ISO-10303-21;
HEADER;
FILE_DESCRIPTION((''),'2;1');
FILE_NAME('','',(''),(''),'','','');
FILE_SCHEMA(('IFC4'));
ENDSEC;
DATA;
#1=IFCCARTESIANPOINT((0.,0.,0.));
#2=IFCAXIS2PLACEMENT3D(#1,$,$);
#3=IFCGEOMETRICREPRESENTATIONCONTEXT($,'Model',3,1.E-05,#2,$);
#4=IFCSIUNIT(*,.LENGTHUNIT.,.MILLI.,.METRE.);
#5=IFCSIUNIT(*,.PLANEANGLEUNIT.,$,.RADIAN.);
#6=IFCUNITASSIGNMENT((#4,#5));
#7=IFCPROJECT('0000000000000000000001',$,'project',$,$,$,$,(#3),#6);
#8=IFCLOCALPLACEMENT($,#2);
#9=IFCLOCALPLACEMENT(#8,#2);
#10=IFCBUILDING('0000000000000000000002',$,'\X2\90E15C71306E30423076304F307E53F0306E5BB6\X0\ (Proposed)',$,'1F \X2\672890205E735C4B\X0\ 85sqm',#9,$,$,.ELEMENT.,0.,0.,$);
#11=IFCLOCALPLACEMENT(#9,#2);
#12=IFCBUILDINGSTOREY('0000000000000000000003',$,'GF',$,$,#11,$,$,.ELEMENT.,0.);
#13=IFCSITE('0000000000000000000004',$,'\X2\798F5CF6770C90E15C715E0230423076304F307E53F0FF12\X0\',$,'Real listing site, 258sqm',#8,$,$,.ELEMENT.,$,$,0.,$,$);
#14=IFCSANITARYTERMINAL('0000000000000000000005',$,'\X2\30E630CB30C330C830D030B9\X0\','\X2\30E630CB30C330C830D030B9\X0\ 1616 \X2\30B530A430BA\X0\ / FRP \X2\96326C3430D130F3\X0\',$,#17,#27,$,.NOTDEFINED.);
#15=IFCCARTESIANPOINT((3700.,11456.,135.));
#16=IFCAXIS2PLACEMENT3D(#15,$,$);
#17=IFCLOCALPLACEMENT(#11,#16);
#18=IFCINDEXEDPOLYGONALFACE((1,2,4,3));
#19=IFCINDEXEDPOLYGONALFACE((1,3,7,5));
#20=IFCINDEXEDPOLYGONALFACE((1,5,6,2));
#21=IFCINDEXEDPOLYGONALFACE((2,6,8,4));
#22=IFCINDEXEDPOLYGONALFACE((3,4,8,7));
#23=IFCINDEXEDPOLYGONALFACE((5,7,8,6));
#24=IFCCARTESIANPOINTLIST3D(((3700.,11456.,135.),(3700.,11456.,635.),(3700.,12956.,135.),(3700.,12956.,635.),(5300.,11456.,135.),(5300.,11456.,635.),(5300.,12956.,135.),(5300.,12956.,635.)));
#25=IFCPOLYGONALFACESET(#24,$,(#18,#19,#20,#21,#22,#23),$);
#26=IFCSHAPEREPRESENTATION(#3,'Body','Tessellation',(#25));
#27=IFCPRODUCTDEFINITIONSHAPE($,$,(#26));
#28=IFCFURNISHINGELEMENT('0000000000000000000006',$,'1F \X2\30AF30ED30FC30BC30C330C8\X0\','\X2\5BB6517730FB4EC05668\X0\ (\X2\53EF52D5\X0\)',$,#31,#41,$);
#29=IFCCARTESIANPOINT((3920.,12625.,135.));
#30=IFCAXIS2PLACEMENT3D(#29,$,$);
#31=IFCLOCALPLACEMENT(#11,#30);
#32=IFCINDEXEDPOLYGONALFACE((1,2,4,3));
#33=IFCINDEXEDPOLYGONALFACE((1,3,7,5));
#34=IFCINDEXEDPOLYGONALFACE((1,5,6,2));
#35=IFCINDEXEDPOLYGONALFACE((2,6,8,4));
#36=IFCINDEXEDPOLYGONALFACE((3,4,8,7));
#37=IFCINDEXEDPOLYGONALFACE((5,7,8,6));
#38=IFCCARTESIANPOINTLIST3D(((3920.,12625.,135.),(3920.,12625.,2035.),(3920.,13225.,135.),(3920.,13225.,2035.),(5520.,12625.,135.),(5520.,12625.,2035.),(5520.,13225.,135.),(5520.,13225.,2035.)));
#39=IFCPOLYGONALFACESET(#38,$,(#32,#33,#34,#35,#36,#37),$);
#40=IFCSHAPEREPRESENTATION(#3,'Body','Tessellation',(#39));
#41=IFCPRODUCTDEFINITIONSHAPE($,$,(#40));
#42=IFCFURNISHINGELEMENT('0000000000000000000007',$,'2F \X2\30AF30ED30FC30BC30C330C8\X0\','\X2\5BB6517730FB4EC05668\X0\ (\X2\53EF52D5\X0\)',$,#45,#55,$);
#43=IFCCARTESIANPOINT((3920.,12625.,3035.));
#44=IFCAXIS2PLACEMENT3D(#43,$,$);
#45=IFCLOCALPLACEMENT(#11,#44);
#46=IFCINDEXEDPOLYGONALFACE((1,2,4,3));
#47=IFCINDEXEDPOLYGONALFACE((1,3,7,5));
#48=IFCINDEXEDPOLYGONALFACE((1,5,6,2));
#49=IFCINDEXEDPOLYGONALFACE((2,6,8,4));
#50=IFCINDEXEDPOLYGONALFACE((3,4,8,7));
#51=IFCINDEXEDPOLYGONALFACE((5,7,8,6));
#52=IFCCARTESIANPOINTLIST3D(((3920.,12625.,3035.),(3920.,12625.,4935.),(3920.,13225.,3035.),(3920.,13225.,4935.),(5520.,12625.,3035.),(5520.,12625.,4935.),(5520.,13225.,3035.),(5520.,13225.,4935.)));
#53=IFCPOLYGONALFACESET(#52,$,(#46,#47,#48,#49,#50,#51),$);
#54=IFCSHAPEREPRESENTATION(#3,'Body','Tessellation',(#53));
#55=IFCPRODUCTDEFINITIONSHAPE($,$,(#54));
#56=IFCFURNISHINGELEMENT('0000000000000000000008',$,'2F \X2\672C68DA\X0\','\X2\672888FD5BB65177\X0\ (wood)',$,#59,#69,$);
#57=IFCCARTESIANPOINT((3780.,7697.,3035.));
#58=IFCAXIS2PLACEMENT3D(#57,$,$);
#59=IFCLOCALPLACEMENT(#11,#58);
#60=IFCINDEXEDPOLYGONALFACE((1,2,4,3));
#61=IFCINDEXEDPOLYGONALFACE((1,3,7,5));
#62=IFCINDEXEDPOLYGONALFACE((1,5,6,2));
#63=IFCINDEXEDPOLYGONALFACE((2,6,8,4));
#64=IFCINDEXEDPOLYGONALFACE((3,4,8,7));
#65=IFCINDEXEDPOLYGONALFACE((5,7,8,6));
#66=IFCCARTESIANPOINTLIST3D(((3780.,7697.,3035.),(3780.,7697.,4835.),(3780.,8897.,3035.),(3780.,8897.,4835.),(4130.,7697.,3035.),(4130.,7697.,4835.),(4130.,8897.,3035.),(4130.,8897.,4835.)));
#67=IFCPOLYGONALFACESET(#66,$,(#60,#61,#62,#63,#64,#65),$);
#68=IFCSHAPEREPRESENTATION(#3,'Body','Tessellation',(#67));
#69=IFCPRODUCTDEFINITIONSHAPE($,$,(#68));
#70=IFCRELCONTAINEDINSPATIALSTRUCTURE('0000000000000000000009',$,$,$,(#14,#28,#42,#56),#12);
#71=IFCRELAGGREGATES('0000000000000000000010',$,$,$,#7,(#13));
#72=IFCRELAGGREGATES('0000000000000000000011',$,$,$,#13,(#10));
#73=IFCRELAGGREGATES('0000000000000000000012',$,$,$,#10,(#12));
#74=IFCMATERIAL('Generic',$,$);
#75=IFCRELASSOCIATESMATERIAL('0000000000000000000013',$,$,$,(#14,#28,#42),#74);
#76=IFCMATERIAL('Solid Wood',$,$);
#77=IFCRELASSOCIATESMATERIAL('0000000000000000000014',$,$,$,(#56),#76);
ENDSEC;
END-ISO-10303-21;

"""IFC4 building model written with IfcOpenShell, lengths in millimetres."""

from ifc_helpers import new_model, si_unit, frame, frame_2d, origin, place, context, project, spatial, rectangle, extrude, material, element, save


model = new_model("IFC4")

# Units and contexts
model_context = context("Model", 3, precision=1e-05, world=origin())
ifc_project = project(units=[si_unit("LENGTHUNIT", "METRE", prefix="MILLI"), si_unit("PLANEANGLEUNIT", "RADIAN")], contexts=[model_context])

# Site, building, storey
site_placement = place(None, origin())
site = spatial("IfcSite", under=ifc_project, at=site_placement, Name="福島県郡山市あぶくま台２", ObjectType="Real listing site, 258sqm", CompositionType="ELEMENT", RefElevation=0.0)
building_placement = place(site_placement, origin())
building = spatial("IfcBuilding", under=site, at=building_placement, Name="郡山のあぶくま台の家 (Proposed)", ObjectType="1F 木造平屋 85sqm", CompositionType="ELEMENT", ElevationOfRefHeight=0.0, ElevationOfTerrain=0.0)
storey_placement = place(building_placement, origin())
storey = spatial("IfcBuildingStorey", under=building, at=storey_placement, Name="GF", CompositionType="ELEMENT", Elevation=0.0)

# Shared definitions
ifc_material_1 = material(Name="Solid Wood")

# Shared definitions
ifc_material_2 = material(Name="Generic")

# Sanitary terminal
sanitary_terminal_placement = place(storey_placement, frame((3700.0, 11456.0, 135.0)))
element("IfcSanitaryTerminal", 1, at=sanitary_terminal_placement, inside=storey, material=ifc_material_2, Name="ユニットバス", Description="ユニットバス 1616 サイズ / FRP 防水パン", PredefinedType="NOTDEFINED", context=model_context, shape_type="SweptSolid", body=[
    extrude(rectangle(XDim=1600.0, YDim=1500.0, at=frame_2d((800.0, 750.0))), frame((3700.0, 11456.0, 135.0)), (0.0, 0.0, 1.0), 500.0),
])

# Furnishing elements
furnishing_1_placement = place(storey_placement, frame((3920.0, 12625.0, 135.0)))
element("IfcFurnishingElement", 2, at=furnishing_1_placement, inside=storey, material=ifc_material_2, Name="1F クローゼット", Description="家具・什器 (可動)", context=model_context, shape_type="SweptSolid", body=[
    extrude(rectangle(XDim=1600.0, YDim=600.0, at=frame_2d((800.0, 300.0))), frame((3920.0, 12625.0, 135.0)), (0.0, 0.0, 1.0), 1900.0),
])
furnishing_2_placement = place(storey_placement, frame((3920.0, 12625.0, 3035.0)))
element("IfcFurnishingElement", 3, at=furnishing_2_placement, inside=storey, material=ifc_material_2, Name="2F クローゼット", Description="家具・什器 (可動)", context=model_context, shape_type="SweptSolid", body=[
    extrude(rectangle(XDim=1600.0, YDim=600.0, at=frame_2d((800.0, 300.0))), frame((3920.0, 12625.0, 3035.0)), (0.0, 0.0, 1.0), 1900.0),
])
furnishing_3_placement = place(storey_placement, frame((3780.0, 7697.0, 3035.0)))
element("IfcFurnishingElement", 4, at=furnishing_3_placement, inside=storey, material=ifc_material_1, Name="2F 本棚", Description="木製家具 (wood)", context=model_context, shape_type="SweptSolid", body=[
    extrude(rectangle(XDim=350.0, YDim=1200.0, at=frame_2d((175.0, 600.0))), frame((3780.0, 7697.0, 3035.0)), (0.0, 0.0, 1.0), 1800.0),
])

save(model, "model.ifc")
